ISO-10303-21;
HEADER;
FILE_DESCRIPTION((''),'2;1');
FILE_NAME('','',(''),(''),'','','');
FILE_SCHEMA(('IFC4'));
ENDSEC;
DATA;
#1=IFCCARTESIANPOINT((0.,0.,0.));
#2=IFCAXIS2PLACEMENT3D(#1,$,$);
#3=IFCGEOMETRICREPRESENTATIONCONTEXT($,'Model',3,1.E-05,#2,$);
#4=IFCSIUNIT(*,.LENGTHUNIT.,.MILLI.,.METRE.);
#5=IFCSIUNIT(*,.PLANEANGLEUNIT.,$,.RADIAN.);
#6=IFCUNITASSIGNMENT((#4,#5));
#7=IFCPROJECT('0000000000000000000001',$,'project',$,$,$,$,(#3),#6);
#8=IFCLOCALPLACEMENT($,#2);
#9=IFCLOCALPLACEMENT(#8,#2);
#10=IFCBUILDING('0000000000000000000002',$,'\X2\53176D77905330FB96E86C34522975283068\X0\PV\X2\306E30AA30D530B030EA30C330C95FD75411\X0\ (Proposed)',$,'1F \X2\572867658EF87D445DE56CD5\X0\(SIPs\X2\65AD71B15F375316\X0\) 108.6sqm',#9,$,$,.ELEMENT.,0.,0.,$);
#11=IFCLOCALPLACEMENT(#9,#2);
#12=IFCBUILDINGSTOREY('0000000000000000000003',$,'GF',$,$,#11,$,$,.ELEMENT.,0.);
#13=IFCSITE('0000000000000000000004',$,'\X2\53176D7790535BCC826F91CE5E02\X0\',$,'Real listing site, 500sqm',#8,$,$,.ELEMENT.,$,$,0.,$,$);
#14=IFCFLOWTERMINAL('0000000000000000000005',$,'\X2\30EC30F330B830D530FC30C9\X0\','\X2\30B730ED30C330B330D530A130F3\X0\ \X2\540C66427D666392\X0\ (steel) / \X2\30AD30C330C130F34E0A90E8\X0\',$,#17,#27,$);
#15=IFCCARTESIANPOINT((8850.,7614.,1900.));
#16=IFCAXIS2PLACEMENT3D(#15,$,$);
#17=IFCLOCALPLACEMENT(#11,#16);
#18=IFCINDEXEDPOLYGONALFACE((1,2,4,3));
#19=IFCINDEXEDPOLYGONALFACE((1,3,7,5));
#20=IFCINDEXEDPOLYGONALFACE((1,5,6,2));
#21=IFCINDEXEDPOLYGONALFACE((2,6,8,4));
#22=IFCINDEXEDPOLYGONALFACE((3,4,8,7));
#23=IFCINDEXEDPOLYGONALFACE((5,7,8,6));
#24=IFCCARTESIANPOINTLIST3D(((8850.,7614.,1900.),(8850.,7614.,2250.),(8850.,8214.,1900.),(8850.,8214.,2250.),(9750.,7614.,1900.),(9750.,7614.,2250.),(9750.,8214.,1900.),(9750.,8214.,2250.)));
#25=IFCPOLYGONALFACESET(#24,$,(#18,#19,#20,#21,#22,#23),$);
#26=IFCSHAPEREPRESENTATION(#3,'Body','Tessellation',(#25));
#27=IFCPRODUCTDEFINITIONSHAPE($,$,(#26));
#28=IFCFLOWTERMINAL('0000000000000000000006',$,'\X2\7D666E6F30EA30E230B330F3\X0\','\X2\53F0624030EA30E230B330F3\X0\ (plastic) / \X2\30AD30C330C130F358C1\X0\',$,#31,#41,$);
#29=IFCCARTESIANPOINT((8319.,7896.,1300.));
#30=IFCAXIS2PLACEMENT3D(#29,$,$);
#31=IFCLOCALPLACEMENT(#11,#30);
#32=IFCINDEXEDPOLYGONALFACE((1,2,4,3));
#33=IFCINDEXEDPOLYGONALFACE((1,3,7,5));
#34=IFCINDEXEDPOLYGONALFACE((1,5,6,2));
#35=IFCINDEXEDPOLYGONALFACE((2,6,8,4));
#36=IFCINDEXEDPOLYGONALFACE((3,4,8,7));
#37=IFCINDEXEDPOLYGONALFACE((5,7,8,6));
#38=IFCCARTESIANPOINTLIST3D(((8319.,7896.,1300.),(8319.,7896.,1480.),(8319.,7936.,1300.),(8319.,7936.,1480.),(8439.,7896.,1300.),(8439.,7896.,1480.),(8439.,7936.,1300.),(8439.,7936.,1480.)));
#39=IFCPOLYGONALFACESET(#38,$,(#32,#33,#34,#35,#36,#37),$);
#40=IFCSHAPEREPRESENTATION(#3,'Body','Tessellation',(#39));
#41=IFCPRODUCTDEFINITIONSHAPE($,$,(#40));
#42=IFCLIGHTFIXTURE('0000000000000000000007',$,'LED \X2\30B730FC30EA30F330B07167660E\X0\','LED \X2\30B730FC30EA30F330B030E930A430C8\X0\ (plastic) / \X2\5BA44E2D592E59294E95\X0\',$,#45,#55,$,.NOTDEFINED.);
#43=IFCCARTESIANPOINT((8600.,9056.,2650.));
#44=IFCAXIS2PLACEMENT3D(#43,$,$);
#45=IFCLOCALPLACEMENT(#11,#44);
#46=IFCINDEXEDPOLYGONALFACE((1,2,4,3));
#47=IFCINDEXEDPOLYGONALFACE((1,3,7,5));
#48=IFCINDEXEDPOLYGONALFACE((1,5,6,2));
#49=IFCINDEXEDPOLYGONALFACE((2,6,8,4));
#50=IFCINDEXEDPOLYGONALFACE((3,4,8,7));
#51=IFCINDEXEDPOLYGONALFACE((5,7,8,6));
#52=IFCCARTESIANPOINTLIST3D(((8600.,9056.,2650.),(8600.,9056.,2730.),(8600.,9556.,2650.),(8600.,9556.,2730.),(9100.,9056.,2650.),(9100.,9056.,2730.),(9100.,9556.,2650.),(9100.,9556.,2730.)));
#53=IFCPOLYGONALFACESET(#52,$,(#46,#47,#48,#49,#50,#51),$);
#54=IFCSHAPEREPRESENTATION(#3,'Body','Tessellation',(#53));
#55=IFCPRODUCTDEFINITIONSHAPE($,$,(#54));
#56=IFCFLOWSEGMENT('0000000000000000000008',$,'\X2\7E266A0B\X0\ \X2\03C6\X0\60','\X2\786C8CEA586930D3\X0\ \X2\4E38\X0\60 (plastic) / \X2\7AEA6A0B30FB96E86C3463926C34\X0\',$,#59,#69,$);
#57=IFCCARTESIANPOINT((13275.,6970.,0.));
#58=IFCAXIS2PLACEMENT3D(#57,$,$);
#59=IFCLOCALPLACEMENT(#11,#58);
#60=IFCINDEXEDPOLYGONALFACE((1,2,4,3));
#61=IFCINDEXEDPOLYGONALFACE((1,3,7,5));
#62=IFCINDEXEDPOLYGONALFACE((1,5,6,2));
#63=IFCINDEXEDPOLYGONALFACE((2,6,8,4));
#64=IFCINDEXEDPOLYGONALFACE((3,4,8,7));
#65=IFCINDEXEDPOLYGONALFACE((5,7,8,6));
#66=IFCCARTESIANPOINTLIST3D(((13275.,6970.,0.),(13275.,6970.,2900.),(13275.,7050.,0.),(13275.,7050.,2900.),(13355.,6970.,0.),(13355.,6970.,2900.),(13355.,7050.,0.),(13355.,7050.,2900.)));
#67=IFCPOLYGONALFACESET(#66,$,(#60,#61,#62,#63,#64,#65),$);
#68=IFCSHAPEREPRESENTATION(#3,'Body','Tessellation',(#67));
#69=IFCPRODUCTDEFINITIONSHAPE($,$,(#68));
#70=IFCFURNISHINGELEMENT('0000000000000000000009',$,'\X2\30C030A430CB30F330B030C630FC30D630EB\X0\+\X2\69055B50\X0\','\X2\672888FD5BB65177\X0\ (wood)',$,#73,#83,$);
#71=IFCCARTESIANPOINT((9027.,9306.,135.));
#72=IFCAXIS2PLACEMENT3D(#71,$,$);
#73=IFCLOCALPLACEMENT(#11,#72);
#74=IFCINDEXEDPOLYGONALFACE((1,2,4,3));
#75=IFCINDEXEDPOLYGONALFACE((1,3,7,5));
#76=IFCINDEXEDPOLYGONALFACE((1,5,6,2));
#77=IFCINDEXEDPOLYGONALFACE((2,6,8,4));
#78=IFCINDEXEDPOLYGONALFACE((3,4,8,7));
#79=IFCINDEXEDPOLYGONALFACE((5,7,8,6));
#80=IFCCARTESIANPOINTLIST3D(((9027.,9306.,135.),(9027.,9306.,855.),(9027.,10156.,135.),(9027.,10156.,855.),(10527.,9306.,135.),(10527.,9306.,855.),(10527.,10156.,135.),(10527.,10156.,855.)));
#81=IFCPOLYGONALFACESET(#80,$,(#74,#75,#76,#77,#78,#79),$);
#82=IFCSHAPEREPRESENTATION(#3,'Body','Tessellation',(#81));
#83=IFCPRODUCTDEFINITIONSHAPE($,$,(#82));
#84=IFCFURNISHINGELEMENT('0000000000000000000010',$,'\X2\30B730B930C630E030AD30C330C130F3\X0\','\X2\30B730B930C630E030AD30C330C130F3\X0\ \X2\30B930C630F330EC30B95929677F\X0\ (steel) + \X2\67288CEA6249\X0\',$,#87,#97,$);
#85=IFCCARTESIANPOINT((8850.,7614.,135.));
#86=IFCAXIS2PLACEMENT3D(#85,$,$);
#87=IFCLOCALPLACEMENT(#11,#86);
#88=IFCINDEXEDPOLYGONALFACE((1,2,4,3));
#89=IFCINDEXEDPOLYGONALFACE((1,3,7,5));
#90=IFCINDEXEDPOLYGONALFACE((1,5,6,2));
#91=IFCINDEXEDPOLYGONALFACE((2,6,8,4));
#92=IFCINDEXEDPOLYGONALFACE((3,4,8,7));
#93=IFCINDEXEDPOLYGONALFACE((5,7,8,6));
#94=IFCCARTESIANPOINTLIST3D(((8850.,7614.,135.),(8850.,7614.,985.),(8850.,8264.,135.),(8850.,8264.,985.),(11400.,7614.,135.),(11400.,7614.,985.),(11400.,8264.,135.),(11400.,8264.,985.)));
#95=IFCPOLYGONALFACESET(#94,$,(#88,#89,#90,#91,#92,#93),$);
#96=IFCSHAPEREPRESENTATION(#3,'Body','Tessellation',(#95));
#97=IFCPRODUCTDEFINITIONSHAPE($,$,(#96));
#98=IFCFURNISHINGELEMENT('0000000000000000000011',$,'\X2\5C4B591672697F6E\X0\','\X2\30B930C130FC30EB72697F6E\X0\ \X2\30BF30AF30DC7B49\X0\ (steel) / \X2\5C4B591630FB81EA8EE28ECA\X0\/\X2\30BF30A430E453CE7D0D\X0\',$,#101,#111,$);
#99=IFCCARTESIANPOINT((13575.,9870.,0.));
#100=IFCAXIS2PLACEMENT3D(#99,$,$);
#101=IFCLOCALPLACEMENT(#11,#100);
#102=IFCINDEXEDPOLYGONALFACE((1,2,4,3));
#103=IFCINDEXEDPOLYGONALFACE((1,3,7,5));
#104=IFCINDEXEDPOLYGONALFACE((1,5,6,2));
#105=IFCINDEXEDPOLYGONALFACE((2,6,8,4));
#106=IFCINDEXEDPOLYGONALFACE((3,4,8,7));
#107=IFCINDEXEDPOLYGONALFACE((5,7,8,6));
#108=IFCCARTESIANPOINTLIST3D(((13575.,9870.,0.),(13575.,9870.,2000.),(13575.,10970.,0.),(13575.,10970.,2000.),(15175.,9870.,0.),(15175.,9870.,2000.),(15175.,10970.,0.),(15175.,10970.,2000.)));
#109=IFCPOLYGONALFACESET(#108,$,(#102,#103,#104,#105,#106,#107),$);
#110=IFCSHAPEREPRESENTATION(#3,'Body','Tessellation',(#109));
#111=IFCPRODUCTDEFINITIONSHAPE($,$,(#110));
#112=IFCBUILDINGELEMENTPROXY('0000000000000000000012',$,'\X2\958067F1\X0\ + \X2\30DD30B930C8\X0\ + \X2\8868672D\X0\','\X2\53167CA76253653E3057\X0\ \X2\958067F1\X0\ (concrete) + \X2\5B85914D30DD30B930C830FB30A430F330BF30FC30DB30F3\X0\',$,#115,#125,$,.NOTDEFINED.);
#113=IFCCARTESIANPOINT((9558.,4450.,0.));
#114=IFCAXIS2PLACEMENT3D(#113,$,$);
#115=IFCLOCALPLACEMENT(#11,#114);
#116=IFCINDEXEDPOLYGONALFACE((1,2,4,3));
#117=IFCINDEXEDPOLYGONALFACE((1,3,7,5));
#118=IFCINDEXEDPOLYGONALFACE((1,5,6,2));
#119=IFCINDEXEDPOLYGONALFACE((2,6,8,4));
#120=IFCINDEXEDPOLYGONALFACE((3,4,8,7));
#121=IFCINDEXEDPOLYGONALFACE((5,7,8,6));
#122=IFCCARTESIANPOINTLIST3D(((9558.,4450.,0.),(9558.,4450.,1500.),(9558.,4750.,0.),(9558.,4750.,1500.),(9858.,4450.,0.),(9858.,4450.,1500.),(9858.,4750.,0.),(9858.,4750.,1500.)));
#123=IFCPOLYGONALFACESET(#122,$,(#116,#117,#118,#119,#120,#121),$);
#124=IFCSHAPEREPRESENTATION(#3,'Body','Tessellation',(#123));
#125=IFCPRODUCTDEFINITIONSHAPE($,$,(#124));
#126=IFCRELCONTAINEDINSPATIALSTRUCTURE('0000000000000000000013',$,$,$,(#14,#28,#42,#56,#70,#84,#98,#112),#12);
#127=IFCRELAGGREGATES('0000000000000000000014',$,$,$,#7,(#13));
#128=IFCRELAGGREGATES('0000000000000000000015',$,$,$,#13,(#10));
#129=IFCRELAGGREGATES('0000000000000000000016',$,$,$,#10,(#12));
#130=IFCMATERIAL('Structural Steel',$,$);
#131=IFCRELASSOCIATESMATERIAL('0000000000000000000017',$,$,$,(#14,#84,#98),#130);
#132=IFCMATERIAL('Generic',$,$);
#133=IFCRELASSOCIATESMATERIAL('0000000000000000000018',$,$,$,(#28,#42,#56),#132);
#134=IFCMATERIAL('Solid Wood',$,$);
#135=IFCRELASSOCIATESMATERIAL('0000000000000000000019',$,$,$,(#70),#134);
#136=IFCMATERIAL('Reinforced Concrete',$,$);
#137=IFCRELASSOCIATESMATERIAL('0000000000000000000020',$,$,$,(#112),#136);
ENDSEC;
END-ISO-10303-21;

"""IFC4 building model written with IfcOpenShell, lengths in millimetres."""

from ifc_helpers import new_model, si_unit, frame, frame_2d, origin, place, context, project, spatial, rectangle, extrude, material, element, save


model = new_model("IFC4")

# Units and contexts
model_context = context("Model", 3, precision=1e-05, world=origin())
ifc_project = project(units=[si_unit("LENGTHUNIT", "METRE", prefix="MILLI"), si_unit("PLANEANGLEUNIT", "RADIAN")], contexts=[model_context])

# Site, building, storey
site_placement = place(None, origin())
site = spatial("IfcSite", under=ifc_project, at=site_placement, Name="北海道富良野市", ObjectType="Real listing site, 500sqm", CompositionType="ELEMENT", RefElevation=0.0)
building_placement = place(site_placement, origin())
building = spatial("IfcBuilding", under=site, at=building_placement, Name="北海道・雨水利用とPVのオフグリッド志向 (Proposed)", ObjectType="1F 在来軸組工法(SIPs断熱強化) 108.6sqm", CompositionType="ELEMENT", ElevationOfRefHeight=0.0, ElevationOfTerrain=0.0)
storey_placement = place(building_placement, origin())
storey = spatial("IfcBuildingStorey", under=building, at=storey_placement, Name="GF", CompositionType="ELEMENT", Elevation=0.0)

# Shared definitions
ifc_material_1 = material(Name="Solid Wood")

# Shared definitions
ifc_material_2 = material(Name="Structural Steel")

# Shared definitions
ifc_material_3 = material(Name="Reinforced Concrete")

# Flow terminals
flow_terminal_1_placement = place(storey_placement, frame((8850.0, 7614.0, 1900.0)))
element("IfcFlowTerminal", 1, at=flow_terminal_1_placement, inside=storey, material=ifc_material_2, Name="レンジフード", Description="シロッコファン 同時給排 (steel) / キッチン上部", context=model_context, shape_type="SweptSolid", body=[
    extrude(rectangle(XDim=900.0, YDim=600.0, at=frame_2d((450.0, 300.0))), frame((8850.0, 7614.0, 1900.0)), (0.0, 0.0, 1.0), 350.0),
])
ifc_material_4 = material(Name="Generic")
flow_terminal_2_placement = place(storey_placement, frame((8319.0, 7896.0, 1300.0)))
element("IfcFlowTerminal", 2, at=flow_terminal_2_placement, inside=storey, material=ifc_material_4, Name="給湯リモコン", Description="台所リモコン (plastic) / キッチン壁", context=model_context, shape_type="SweptSolid", body=[
    extrude(rectangle(XDim=120.0, YDim=40.0, at=frame_2d((60.0, 20.0))), frame((8319.0, 7896.0, 1300.0)), (0.0, 0.0, 1.0), 180.0),
])

# Light fixture
light_fixture_placement = place(storey_placement, frame((8600.0, 9056.0, 2650.0)))
element("IfcLightFixture", 3, at=light_fixture_placement, inside=storey, material=ifc_material_4, Name="LED シーリング照明", Description="LED シーリングライト (plastic) / 室中央天井", PredefinedType="NOTDEFINED", context=model_context, shape_type="SweptSolid", body=[
    extrude(rectangle(XDim=500.0, YDim=500.0, at=frame_2d((250.0, 250.0))), frame((8600.0, 9056.0, 2650.0)), (0.0, 0.0, 1.0), 80.0),
])

# Flow segment
flow_segment_placement = place(storey_placement, frame((13275.0, 6970.0, 0.0)))
element("IfcFlowSegment", 4, at=flow_segment_placement, inside=storey, material=ifc_material_4, Name="縦樋 φ60", Description="硬質塩ビ 丸60 (plastic) / 竪樋・雨水排水", context=model_context, shape_type="SweptSolid", body=[
    extrude(rectangle(XDim=80.0, YDim=80.0, at=frame_2d((40.0, 40.0))), frame((13275.0, 6970.0, 0.0)), (0.0, 0.0, 1.0), 2900.0),
])

# Furnishing elements
furnishing_1_placement = place(storey_placement, frame((9027.0, 9306.0, 135.0)))
element("IfcFurnishingElement", 5, at=furnishing_1_placement, inside=storey, material=ifc_material_1, Name="ダイニングテーブル+椅子", Description="木製家具 (wood)", context=model_context, shape_type="SweptSolid", body=[
    extrude(rectangle(XDim=1500.0, YDim=850.0, at=frame_2d((750.0, 425.0))), frame((9027.0, 9306.0, 135.0)), (0.0, 0.0, 1.0), 720.0),
])
furnishing_2_placement = place(storey_placement, frame((8850.0, 7614.0, 135.0)))
element("IfcFurnishingElement", 6, at=furnishing_2_placement, inside=storey, material=ifc_material_2, Name="システムキッチン", Description="システムキッチン ステンレス天板 (steel) + 木質扉", context=model_context, shape_type="SweptSolid", body=[
    extrude(rectangle(XDim=2550.0, YDim=650.0, at=frame_2d((1275.0, 325.0))), frame((8850.0, 7614.0, 135.0)), (0.0, 0.0, 1.0), 850.0),
])
furnishing_3_placement = place(storey_placement, frame((13575.0, 9870.0, 0.0)))
element("IfcFurnishingElement", 7, at=furnishing_3_placement, inside=storey, material=ifc_material_2, Name="屋外物置", Description="スチール物置 タクボ等 (steel) / 屋外・自転車/タイヤ収納", context=model_context, shape_type="SweptSolid", body=[
    extrude(rectangle(XDim=1600.0, YDim=1100.0, at=frame_2d((800.0, 550.0))), frame((13575.0, 9870.0, 0.0)), (0.0, 0.0, 1.0), 2000.0),
])

# Building element proxy
proxy_placement = place(storey_placement, frame((9558.0, 4450.0, 0.0)))
element("IfcBuildingElementProxy", 8, at=proxy_placement, inside=storey, material=ifc_material_3, Name="門柱 + ポスト + 表札", Description="化粧打放し 門柱 (concrete) + 宅配ポスト・インターホン", PredefinedType="NOTDEFINED", context=model_context, shape_type="SweptSolid", body=[
    extrude(rectangle(XDim=300.0, YDim=300.0, at=frame_2d((150.0, 150.0))), frame((9558.0, 4450.0, 0.0)), (0.0, 0.0, 1.0), 1500.0),
])

save(model, "model.ifc")
